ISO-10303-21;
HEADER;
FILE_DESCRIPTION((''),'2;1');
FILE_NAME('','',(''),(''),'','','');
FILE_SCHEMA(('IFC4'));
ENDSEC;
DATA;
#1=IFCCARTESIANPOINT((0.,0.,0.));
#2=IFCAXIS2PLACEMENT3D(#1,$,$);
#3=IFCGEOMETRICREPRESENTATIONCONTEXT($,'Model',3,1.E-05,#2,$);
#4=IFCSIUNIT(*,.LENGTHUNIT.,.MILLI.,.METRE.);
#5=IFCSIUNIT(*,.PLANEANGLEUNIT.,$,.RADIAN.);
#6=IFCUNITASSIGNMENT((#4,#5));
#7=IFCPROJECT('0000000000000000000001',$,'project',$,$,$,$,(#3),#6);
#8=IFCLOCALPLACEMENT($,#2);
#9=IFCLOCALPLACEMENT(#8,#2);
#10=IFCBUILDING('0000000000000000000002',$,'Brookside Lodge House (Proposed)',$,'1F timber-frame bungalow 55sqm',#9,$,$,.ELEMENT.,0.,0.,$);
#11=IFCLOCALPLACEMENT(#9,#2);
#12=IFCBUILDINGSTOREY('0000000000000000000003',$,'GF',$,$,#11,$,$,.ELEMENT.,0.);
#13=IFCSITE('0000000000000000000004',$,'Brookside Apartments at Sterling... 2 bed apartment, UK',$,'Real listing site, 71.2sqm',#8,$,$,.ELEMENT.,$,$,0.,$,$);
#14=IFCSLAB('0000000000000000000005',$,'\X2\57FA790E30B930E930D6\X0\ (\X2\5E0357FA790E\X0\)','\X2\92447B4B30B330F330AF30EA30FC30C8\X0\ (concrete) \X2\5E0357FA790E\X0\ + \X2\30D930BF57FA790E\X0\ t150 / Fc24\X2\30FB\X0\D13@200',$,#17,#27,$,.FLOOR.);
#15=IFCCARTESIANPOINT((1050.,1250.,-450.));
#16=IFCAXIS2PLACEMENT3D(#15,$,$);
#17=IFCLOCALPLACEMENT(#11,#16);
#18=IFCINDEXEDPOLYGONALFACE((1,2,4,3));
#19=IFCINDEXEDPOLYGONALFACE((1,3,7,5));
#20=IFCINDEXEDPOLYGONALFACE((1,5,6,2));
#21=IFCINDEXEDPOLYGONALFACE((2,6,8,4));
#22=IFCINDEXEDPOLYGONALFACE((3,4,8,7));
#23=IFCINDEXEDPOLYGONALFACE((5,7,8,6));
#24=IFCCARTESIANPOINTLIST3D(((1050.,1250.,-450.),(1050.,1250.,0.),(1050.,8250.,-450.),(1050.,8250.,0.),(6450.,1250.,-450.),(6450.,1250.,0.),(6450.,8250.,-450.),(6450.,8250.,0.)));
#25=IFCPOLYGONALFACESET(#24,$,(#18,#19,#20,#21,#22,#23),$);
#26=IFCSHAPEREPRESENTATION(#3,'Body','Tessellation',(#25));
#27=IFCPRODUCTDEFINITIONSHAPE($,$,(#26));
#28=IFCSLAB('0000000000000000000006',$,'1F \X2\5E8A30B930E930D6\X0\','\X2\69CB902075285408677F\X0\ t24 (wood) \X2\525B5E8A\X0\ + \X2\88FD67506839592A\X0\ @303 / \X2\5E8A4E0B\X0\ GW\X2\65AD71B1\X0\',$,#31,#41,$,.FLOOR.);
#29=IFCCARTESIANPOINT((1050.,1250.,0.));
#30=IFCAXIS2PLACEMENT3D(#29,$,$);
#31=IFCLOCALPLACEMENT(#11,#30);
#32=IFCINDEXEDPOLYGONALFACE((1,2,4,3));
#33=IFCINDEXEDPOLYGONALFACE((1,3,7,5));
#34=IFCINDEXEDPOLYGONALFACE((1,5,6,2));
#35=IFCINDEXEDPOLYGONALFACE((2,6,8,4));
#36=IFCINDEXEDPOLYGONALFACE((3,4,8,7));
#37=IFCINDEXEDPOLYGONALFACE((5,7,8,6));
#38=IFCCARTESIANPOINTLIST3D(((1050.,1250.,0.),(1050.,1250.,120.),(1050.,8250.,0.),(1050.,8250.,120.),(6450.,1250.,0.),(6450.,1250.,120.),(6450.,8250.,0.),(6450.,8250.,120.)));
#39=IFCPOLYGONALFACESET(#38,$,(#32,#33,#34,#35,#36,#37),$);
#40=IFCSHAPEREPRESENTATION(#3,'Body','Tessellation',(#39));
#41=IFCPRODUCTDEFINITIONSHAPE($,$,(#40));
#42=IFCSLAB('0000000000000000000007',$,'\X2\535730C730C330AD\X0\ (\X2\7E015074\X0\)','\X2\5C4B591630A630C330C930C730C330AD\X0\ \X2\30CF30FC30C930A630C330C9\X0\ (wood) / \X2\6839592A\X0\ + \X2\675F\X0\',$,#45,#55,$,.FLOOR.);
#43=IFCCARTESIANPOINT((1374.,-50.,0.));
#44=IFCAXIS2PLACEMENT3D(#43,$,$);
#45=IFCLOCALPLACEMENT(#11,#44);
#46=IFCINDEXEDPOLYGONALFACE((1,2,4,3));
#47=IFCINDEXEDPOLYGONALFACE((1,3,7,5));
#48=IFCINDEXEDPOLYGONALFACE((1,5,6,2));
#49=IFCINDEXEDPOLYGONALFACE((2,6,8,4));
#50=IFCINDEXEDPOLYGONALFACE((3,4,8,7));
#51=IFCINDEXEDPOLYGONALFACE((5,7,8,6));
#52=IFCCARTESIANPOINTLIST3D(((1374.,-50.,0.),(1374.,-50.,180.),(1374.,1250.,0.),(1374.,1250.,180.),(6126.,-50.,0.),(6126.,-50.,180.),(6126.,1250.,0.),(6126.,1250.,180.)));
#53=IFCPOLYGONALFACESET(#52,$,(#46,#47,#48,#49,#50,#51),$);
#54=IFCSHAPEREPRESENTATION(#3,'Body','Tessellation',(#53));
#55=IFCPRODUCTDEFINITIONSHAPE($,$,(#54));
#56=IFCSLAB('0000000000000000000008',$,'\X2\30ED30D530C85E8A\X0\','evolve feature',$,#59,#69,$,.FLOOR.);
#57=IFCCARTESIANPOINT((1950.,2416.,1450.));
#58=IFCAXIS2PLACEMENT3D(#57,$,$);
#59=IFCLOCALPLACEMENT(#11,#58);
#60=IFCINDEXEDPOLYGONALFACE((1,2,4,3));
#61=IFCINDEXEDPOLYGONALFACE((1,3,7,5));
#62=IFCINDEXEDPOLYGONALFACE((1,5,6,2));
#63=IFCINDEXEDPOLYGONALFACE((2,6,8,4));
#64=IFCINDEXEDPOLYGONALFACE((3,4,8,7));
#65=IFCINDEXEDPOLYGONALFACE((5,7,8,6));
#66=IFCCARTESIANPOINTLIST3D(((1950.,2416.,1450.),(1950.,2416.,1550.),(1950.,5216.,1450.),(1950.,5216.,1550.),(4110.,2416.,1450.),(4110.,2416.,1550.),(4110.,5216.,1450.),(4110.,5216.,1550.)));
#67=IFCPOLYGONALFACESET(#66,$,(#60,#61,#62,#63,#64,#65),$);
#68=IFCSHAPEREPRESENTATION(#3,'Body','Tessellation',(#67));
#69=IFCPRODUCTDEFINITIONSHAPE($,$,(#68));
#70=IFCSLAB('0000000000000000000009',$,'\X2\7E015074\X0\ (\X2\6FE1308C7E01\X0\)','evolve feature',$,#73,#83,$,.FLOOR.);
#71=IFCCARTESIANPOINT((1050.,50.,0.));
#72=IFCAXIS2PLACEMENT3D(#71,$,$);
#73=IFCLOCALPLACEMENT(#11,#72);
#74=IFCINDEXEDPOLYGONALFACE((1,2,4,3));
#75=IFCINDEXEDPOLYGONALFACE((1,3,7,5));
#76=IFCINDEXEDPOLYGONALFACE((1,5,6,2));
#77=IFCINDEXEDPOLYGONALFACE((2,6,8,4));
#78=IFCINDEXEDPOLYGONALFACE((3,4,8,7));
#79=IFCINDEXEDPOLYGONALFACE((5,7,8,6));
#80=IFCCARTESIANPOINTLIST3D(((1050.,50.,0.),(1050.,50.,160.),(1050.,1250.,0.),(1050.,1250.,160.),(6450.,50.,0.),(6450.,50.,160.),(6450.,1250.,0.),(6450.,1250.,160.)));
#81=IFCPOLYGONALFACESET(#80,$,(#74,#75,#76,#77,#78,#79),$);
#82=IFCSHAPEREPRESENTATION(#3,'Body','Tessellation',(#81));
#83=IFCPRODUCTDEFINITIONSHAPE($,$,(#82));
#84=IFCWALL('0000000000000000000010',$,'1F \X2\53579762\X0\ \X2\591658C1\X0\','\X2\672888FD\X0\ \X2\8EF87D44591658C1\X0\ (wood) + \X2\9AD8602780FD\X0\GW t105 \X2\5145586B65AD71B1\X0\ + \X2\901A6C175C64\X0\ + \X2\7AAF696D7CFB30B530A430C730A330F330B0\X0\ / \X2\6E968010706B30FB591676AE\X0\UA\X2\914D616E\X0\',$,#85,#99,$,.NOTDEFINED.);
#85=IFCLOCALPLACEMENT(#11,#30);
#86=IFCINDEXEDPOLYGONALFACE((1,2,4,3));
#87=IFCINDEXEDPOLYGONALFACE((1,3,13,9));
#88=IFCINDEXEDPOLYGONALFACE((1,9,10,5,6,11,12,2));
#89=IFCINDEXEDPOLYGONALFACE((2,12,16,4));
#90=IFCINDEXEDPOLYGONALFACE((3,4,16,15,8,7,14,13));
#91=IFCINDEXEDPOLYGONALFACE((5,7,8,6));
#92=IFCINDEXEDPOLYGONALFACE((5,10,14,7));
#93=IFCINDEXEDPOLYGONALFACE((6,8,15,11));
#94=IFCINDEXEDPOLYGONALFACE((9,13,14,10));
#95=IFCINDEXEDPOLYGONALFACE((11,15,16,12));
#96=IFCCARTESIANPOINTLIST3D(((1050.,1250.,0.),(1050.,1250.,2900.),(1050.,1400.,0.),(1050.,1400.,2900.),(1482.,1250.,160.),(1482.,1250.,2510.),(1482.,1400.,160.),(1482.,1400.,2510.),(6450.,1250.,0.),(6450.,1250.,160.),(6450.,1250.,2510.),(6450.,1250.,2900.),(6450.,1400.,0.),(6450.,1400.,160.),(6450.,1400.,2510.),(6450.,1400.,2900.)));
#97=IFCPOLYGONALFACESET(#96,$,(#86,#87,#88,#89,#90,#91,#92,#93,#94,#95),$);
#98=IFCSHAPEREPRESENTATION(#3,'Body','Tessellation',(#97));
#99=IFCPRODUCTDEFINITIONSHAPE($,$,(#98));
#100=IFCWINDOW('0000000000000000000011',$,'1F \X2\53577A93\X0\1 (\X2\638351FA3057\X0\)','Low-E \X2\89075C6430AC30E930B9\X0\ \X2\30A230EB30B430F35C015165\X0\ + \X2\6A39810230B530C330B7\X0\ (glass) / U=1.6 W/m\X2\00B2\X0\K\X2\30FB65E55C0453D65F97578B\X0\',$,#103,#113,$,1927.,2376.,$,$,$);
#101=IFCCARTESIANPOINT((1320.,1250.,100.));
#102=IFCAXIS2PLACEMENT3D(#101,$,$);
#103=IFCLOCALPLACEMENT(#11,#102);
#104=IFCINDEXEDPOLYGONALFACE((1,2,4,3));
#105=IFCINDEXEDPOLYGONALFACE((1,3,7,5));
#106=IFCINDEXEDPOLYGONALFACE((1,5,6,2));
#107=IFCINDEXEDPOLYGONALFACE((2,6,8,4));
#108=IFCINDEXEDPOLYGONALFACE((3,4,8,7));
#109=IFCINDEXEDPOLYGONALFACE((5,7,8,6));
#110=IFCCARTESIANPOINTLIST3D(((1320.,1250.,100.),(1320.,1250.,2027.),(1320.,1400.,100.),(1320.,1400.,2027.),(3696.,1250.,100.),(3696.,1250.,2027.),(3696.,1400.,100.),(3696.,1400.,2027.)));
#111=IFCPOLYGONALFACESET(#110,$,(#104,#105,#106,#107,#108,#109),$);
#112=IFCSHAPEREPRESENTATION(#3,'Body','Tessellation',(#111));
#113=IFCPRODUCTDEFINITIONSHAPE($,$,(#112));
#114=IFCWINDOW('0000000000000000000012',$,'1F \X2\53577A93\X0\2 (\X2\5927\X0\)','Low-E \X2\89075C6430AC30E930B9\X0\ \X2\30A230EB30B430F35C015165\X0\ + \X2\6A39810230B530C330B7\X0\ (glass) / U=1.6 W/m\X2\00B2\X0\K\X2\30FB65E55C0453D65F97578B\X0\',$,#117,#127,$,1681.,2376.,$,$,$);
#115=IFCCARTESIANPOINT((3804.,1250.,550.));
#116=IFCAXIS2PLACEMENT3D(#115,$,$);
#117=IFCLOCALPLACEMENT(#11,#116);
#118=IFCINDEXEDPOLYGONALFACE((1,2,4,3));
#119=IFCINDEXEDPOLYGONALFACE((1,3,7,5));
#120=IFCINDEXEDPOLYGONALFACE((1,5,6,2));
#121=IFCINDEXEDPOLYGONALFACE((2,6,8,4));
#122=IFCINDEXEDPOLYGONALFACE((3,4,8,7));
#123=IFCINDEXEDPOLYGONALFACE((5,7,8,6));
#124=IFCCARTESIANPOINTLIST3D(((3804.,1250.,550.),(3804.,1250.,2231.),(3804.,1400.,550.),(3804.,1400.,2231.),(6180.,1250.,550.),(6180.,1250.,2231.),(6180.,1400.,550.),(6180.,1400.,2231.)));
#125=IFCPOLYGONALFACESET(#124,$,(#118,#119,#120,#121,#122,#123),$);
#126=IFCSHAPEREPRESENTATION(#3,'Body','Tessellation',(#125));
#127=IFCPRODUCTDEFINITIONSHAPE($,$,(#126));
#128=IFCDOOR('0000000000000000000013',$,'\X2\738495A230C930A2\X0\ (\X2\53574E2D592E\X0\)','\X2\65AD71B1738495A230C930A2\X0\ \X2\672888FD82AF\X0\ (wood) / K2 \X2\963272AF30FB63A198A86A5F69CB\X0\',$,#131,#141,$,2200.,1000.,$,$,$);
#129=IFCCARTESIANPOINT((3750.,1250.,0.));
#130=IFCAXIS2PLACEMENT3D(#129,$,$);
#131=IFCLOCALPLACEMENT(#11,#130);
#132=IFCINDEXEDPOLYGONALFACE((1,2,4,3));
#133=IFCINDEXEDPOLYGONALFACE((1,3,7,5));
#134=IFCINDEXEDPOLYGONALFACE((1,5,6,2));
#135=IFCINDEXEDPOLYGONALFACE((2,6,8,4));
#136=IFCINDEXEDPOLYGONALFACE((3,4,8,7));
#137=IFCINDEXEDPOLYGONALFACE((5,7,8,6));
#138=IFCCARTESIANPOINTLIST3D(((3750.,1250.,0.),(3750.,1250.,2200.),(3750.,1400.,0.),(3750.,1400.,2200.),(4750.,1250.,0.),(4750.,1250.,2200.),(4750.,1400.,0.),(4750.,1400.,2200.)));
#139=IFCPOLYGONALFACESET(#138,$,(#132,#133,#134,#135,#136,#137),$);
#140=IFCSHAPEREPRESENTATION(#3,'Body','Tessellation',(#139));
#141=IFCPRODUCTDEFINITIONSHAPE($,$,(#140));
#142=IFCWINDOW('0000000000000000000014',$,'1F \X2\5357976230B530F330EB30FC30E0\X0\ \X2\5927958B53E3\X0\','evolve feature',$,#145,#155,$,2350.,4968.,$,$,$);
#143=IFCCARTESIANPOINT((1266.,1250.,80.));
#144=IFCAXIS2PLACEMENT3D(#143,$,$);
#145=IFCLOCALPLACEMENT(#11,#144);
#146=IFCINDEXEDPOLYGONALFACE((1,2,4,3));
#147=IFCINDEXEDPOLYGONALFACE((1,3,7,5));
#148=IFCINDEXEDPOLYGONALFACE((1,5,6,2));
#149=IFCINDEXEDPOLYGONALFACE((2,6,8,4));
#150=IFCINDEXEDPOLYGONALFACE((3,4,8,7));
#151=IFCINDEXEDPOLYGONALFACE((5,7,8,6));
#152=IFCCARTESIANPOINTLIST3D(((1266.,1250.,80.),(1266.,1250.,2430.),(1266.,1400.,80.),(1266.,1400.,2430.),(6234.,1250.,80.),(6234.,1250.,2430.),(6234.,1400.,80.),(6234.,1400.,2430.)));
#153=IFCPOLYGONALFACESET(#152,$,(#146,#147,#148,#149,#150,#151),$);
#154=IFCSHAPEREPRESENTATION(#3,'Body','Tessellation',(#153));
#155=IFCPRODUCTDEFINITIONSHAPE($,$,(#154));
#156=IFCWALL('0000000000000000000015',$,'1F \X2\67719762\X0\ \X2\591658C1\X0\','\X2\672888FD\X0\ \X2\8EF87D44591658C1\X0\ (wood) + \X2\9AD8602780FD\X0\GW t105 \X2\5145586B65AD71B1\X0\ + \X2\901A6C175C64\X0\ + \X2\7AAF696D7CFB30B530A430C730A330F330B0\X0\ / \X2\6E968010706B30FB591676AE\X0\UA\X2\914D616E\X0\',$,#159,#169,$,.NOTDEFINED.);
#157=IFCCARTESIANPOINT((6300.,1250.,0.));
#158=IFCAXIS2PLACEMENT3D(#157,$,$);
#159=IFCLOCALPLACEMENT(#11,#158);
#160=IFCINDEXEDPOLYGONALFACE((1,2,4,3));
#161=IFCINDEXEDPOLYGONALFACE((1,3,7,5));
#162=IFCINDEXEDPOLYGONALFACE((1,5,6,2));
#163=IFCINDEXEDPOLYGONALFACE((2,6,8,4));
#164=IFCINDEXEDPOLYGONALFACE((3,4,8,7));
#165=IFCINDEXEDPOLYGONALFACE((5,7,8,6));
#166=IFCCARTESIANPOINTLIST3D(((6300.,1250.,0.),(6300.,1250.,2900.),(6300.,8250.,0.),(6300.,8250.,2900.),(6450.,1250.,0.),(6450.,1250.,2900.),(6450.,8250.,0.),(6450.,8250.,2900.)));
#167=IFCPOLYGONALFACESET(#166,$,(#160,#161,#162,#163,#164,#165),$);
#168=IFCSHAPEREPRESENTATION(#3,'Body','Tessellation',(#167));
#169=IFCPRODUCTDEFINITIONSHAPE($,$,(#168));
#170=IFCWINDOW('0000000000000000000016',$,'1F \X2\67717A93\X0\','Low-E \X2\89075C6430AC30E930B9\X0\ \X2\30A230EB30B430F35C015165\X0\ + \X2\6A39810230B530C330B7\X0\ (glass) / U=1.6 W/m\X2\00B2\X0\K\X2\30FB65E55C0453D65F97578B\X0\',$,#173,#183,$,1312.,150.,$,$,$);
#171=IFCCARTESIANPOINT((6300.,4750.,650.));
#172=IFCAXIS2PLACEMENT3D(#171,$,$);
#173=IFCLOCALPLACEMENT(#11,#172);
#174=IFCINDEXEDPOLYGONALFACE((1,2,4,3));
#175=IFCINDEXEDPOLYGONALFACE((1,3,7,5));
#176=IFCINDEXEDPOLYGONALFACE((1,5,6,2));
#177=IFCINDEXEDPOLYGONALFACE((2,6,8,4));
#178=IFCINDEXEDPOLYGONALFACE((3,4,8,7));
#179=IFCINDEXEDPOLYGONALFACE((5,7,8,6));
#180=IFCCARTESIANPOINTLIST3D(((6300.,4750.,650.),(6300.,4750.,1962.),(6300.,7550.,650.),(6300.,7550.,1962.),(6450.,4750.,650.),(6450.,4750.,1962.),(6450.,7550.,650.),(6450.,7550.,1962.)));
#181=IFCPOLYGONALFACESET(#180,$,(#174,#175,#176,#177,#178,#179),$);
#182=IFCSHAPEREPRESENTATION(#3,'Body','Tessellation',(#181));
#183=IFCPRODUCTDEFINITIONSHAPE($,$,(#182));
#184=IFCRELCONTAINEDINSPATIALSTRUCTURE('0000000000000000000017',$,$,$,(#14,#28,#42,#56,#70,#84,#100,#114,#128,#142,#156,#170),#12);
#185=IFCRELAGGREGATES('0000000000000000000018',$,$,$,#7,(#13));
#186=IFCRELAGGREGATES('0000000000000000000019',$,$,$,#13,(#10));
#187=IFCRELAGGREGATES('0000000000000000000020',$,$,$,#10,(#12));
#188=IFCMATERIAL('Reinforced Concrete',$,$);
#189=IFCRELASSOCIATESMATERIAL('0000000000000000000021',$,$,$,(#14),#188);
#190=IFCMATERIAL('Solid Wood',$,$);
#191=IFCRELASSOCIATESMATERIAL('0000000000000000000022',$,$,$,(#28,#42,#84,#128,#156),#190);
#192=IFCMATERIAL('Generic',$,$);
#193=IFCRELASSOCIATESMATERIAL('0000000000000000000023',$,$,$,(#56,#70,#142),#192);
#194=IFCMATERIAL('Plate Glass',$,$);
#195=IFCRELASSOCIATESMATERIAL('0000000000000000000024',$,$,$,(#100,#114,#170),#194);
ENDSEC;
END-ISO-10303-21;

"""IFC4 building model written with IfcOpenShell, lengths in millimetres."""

from ifc_helpers import new_model, si_unit, frame, frame_2d, origin, place, context, project, spatial, rectangle, extrude, material, element, fill, save


model = new_model("IFC4")

# Units and contexts
model_context = context("Model", 3, precision=1e-05, world=origin())
ifc_project = project(units=[si_unit("LENGTHUNIT", "METRE", prefix="MILLI"), si_unit("PLANEANGLEUNIT", "RADIAN")], contexts=[model_context])

# Site, building, storey
site_placement = place(None, origin())
site = spatial("IfcSite", under=ifc_project, at=site_placement, Name="Brookside Apartments at Sterling... 2 bed apartment, UK", ObjectType="Real listing site, 71.2sqm", CompositionType="ELEMENT", RefElevation=0.0)
building_placement = place(site_placement, origin())
building = spatial("IfcBuilding", under=site, at=building_placement, Name="Brookside Lodge House (Proposed)", ObjectType="1F timber-frame bungalow 55sqm", CompositionType="ELEMENT", ElevationOfRefHeight=0.0, ElevationOfTerrain=0.0)
storey_placement = place(building_placement, origin())
storey = spatial("IfcBuildingStorey", under=building, at=storey_placement, Name="GF", CompositionType="ELEMENT", Elevation=0.0)

# Slabs
ifc_material_1 = material(Name="Reinforced Concrete")
slab_1_placement = place(storey_placement, frame((1050.0, 1250.0, -450.0)))
element("IfcSlab", 1, at=slab_1_placement, inside=storey, material=ifc_material_1, Name="基礎スラブ (布基礎)", Description="鉄筋コンクリート (concrete) 布基礎 + ベタ基礎 t150 / Fc24・D13@200", PredefinedType="FLOOR", context=model_context, shape_type="SweptSolid", body=[
    extrude(rectangle(XDim=5400.0, YDim=7000.0, at=frame_2d((2700.0, 3500.0))), frame((1050.0, 1250.0, -450.0)), (0.0, 0.0, 1.0), 450.0),
])
ifc_material_2 = material(Name="Solid Wood")
slab_2_placement = place(storey_placement, frame((1050.0, 1250.0, 0.0)))
element("IfcSlab", 2, at=slab_2_placement, inside=storey, material=ifc_material_2, Name="1F 床スラブ", Description="構造用合板 t24 (wood) 剛床 + 製材根太 @303 / 床下 GW断熱", PredefinedType="FLOOR", context=model_context, shape_type="SweptSolid", body=[
    extrude(rectangle(XDim=5400.0, YDim=7000.0, at=frame_2d((2700.0, 3500.0))), frame((1050.0, 1250.0, 0.0)), (0.0, 0.0, 1.0), 120.0),
])
slab_3_placement = place(storey_placement, frame((1374.0, -50.0, 0.0)))
element("IfcSlab", 3, at=slab_3_placement, inside=storey, material=ifc_material_2, Name="南デッキ (縁側)", Description="屋外ウッドデッキ ハードウッド (wood) / 根太 + 束", PredefinedType="FLOOR", context=model_context, shape_type="SweptSolid", body=[
    extrude(rectangle(XDim=4752.0, YDim=1300.0, at=frame_2d((2376.0, 650.0))), frame((1374.0, -50.0, 0.0)), (0.0, 0.0, 1.0), 180.0),
])
ifc_material_3 = material(Name="Generic")
slab_4_placement = place(storey_placement, frame((1950.0, 2416.0, 1450.0)))
element("IfcSlab", 4, at=slab_4_placement, inside=storey, material=ifc_material_3, Name="ロフト床", Description="evolve feature", PredefinedType="FLOOR", context=model_context, shape_type="SweptSolid", body=[
    extrude(rectangle(XDim=2160.0, YDim=2800.0, at=frame_2d((1080.0, 1400.0))), frame((1950.0, 2416.0, 1450.0)), (0.0, 0.0, 1.0), 100.0),
])
slab_5_placement = place(storey_placement, frame((1050.0, 50.0, 0.0)))
element("IfcSlab", 5, at=slab_5_placement, inside=storey, material=ifc_material_3, Name="縁側 (濡れ縁)", Description="evolve feature", PredefinedType="FLOOR", context=model_context, shape_type="SweptSolid", body=[
    extrude(rectangle(XDim=5400.0, YDim=1200.0, at=frame_2d((2700.0, 600.0))), frame((1050.0, 50.0, 0.0)), (0.0, 0.0, 1.0), 160.0),
])

# Wall, openings, windows, door
wall_1_placement = place(storey_placement, frame((1050.0, 1250.0, 0.0)))
wall_1 = element("IfcWall", 6, at=wall_1_placement, inside=storey, material=ifc_material_2, Name="1F 南面 外壁", Description="木製 軸組外壁 (wood) + 高性能GW t105 充填断熱 + 通気層 + 窯業系サイディング / 準耐火・外皮UA配慮", PredefinedType="NOTDEFINED", context=model_context, shape_type="SweptSolid", body=[
    extrude(rectangle(XDim=5400.0, YDim=150.0, at=frame_2d((2700.0, 75.0))), frame((1050.0, 1250.0, 0.0)), (0.0, 0.0, 1.0), 2900.0),
])
opening_1_placement = place(storey_placement, frame((1320.0, 1250.0, 100.0)))
opening_1 = element("IfcOpeningElement", 7, at=opening_1_placement, cuts=wall_1, PredefinedType="NOTDEFINED", context=model_context, shape_type="SweptSolid", body=[
    extrude(rectangle(XDim=2376.0, YDim=150.0, at=frame_2d((1188.0, 75.0))), frame((1320.0, 1250.0, 100.0)), (0.0, 0.0, 1.0), 1927.0),
])
opening_2_placement = place(storey_placement, frame((3804.0, 1250.0, 550.0)))
opening_2 = element("IfcOpeningElement", 8, at=opening_2_placement, cuts=wall_1, PredefinedType="NOTDEFINED", context=model_context, shape_type="SweptSolid", body=[
    extrude(rectangle(XDim=2376.0, YDim=150.0, at=frame_2d((1188.0, 75.0))), frame((3804.0, 1250.0, 550.0)), (0.0, 0.0, 1.0), 1681.0),
])
opening_3_placement = place(storey_placement, frame((3750.0, 1250.0, 0.0)))
opening_3 = element("IfcOpeningElement", 9, at=opening_3_placement, cuts=wall_1, PredefinedType="NOTDEFINED", context=model_context, shape_type="SweptSolid", body=[
    extrude(rectangle(XDim=1000.0, YDim=150.0, at=frame_2d((500.0, 75.0))), frame((3750.0, 1250.0, 0.0)), (0.0, 0.0, 1.0), 2200.0),
])
opening_4_placement = place(storey_placement, frame((1266.0, 1250.0, 80.0)))
opening_4 = element("IfcOpeningElement", 10, at=opening_4_placement, cuts=wall_1, PredefinedType="NOTDEFINED", context=model_context, shape_type="SweptSolid", body=[
    extrude(rectangle(XDim=4968.0, YDim=150.0, at=frame_2d((2484.0, 75.0))), frame((1266.0, 1250.0, 80.0)), (0.0, 0.0, 1.0), 2350.0),
])
ifc_material_4 = material(Name="Plate Glass")
window_1_placement = place(storey_placement, frame((1320.0, 1250.0, 100.0)))
window_1 = element("IfcWindow", 11, at=window_1_placement, inside=storey, material=ifc_material_4, Name="1F 南窓1 (掃出し)", Description="Low-E 複層ガラス アルゴン封入 + 樹脂サッシ (glass) / U=1.6 W/m²K・日射取得型", OverallHeight=1927.0, OverallWidth=2376.0, context=model_context, shape_type="SweptSolid", body=[
    extrude(rectangle(XDim=2376.0, YDim=150.0, at=frame_2d((1188.0, 75.0))), frame((1320.0, 1250.0, 100.0)), (0.0, 0.0, 1.0), 1927.0),
])
fill(opening_1, window_1)
window_2_placement = place(storey_placement, frame((3804.0, 1250.0, 550.0)))
window_2 = element("IfcWindow", 12, at=window_2_placement, inside=storey, material=ifc_material_4, Name="1F 南窓2 (大)", Description="Low-E 複層ガラス アルゴン封入 + 樹脂サッシ (glass) / U=1.6 W/m²K・日射取得型", OverallHeight=1681.0, OverallWidth=2376.0, context=model_context, shape_type="SweptSolid", body=[
    extrude(rectangle(XDim=2376.0, YDim=150.0, at=frame_2d((1188.0, 75.0))), frame((3804.0, 1250.0, 550.0)), (0.0, 0.0, 1.0), 1681.0),
])
fill(opening_2, window_2)
door_placement = place(storey_placement, frame((3750.0, 1250.0, 0.0)))
door = element("IfcDoor", 13, at=door_placement, inside=storey, material=ifc_material_2, Name="玄関ドア (南中央)", Description="断熱玄関ドア 木製芯 (wood) / K2 防犯・採風機構", OverallHeight=2200.0, OverallWidth=1000.0, context=model_context, shape_type="SweptSolid", body=[
    extrude(rectangle(XDim=1000.0, YDim=150.0, at=frame_2d((500.0, 75.0))), frame((3750.0, 1250.0, 0.0)), (0.0, 0.0, 1.0), 2200.0),
])
fill(opening_3, door)
window_3_placement = place(storey_placement, frame((1266.0, 1250.0, 80.0)))
window_3 = element("IfcWindow", 14, at=window_3_placement, inside=storey, material=ifc_material_3, Name="1F 南面サンルーム 大開口", Description="evolve feature", OverallHeight=2350.0, OverallWidth=4968.0, context=model_context, shape_type="SweptSolid", body=[
    extrude(rectangle(XDim=4968.0, YDim=150.0, at=frame_2d((2484.0, 75.0))), frame((1266.0, 1250.0, 80.0)), (0.0, 0.0, 1.0), 2350.0),
])
fill(opening_4, window_3)

# Wall, opening, window
wall_2_placement = place(storey_placement, frame((6300.0, 1250.0, 0.0)))
wall_2 = element("IfcWall", 15, at=wall_2_placement, inside=storey, material=ifc_material_2, Name="1F 東面 外壁", Description="木製 軸組外壁 (wood) + 高性能GW t105 充填断熱 + 通気層 + 窯業系サイディング / 準耐火・外皮UA配慮", PredefinedType="NOTDEFINED", context=model_context, shape_type="SweptSolid", body=[
    extrude(rectangle(XDim=150.0, YDim=7000.0, at=frame_2d((75.0, 3500.0))), frame((6300.0, 1250.0, 0.0)), (0.0, 0.0, 1.0), 2900.0),
])
opening_5_placement = place(storey_placement, frame((6300.0, 4750.0, 650.0)))
opening_5 = element("IfcOpeningElement", 16, at=opening_5_placement, cuts=wall_2, PredefinedType="NOTDEFINED", context=model_context, shape_type="SweptSolid", body=[
    extrude(rectangle(XDim=150.0, YDim=2800.0, at=frame_2d((75.0, 1400.0))), frame((6300.0, 4750.0, 650.0)), (0.0, 0.0, 1.0), 1312.0),
])
window_4_placement = place(storey_placement, frame((6300.0, 4750.0, 650.0)))
window_4 = element("IfcWindow", 17, at=window_4_placement, inside=storey, material=ifc_material_4, Name="1F 東窓", Description="Low-E 複層ガラス アルゴン封入 + 樹脂サッシ (glass) / U=1.6 W/m²K・日射取得型", OverallHeight=1312.0, OverallWidth=150.0, context=model_context, shape_type="SweptSolid", body=[
    extrude(rectangle(XDim=150.0, YDim=2800.0, at=frame_2d((75.0, 1400.0))), frame((6300.0, 4750.0, 650.0)), (0.0, 0.0, 1.0), 1312.0),
])
fill(opening_5, window_4)

save(model, "model.ifc")
